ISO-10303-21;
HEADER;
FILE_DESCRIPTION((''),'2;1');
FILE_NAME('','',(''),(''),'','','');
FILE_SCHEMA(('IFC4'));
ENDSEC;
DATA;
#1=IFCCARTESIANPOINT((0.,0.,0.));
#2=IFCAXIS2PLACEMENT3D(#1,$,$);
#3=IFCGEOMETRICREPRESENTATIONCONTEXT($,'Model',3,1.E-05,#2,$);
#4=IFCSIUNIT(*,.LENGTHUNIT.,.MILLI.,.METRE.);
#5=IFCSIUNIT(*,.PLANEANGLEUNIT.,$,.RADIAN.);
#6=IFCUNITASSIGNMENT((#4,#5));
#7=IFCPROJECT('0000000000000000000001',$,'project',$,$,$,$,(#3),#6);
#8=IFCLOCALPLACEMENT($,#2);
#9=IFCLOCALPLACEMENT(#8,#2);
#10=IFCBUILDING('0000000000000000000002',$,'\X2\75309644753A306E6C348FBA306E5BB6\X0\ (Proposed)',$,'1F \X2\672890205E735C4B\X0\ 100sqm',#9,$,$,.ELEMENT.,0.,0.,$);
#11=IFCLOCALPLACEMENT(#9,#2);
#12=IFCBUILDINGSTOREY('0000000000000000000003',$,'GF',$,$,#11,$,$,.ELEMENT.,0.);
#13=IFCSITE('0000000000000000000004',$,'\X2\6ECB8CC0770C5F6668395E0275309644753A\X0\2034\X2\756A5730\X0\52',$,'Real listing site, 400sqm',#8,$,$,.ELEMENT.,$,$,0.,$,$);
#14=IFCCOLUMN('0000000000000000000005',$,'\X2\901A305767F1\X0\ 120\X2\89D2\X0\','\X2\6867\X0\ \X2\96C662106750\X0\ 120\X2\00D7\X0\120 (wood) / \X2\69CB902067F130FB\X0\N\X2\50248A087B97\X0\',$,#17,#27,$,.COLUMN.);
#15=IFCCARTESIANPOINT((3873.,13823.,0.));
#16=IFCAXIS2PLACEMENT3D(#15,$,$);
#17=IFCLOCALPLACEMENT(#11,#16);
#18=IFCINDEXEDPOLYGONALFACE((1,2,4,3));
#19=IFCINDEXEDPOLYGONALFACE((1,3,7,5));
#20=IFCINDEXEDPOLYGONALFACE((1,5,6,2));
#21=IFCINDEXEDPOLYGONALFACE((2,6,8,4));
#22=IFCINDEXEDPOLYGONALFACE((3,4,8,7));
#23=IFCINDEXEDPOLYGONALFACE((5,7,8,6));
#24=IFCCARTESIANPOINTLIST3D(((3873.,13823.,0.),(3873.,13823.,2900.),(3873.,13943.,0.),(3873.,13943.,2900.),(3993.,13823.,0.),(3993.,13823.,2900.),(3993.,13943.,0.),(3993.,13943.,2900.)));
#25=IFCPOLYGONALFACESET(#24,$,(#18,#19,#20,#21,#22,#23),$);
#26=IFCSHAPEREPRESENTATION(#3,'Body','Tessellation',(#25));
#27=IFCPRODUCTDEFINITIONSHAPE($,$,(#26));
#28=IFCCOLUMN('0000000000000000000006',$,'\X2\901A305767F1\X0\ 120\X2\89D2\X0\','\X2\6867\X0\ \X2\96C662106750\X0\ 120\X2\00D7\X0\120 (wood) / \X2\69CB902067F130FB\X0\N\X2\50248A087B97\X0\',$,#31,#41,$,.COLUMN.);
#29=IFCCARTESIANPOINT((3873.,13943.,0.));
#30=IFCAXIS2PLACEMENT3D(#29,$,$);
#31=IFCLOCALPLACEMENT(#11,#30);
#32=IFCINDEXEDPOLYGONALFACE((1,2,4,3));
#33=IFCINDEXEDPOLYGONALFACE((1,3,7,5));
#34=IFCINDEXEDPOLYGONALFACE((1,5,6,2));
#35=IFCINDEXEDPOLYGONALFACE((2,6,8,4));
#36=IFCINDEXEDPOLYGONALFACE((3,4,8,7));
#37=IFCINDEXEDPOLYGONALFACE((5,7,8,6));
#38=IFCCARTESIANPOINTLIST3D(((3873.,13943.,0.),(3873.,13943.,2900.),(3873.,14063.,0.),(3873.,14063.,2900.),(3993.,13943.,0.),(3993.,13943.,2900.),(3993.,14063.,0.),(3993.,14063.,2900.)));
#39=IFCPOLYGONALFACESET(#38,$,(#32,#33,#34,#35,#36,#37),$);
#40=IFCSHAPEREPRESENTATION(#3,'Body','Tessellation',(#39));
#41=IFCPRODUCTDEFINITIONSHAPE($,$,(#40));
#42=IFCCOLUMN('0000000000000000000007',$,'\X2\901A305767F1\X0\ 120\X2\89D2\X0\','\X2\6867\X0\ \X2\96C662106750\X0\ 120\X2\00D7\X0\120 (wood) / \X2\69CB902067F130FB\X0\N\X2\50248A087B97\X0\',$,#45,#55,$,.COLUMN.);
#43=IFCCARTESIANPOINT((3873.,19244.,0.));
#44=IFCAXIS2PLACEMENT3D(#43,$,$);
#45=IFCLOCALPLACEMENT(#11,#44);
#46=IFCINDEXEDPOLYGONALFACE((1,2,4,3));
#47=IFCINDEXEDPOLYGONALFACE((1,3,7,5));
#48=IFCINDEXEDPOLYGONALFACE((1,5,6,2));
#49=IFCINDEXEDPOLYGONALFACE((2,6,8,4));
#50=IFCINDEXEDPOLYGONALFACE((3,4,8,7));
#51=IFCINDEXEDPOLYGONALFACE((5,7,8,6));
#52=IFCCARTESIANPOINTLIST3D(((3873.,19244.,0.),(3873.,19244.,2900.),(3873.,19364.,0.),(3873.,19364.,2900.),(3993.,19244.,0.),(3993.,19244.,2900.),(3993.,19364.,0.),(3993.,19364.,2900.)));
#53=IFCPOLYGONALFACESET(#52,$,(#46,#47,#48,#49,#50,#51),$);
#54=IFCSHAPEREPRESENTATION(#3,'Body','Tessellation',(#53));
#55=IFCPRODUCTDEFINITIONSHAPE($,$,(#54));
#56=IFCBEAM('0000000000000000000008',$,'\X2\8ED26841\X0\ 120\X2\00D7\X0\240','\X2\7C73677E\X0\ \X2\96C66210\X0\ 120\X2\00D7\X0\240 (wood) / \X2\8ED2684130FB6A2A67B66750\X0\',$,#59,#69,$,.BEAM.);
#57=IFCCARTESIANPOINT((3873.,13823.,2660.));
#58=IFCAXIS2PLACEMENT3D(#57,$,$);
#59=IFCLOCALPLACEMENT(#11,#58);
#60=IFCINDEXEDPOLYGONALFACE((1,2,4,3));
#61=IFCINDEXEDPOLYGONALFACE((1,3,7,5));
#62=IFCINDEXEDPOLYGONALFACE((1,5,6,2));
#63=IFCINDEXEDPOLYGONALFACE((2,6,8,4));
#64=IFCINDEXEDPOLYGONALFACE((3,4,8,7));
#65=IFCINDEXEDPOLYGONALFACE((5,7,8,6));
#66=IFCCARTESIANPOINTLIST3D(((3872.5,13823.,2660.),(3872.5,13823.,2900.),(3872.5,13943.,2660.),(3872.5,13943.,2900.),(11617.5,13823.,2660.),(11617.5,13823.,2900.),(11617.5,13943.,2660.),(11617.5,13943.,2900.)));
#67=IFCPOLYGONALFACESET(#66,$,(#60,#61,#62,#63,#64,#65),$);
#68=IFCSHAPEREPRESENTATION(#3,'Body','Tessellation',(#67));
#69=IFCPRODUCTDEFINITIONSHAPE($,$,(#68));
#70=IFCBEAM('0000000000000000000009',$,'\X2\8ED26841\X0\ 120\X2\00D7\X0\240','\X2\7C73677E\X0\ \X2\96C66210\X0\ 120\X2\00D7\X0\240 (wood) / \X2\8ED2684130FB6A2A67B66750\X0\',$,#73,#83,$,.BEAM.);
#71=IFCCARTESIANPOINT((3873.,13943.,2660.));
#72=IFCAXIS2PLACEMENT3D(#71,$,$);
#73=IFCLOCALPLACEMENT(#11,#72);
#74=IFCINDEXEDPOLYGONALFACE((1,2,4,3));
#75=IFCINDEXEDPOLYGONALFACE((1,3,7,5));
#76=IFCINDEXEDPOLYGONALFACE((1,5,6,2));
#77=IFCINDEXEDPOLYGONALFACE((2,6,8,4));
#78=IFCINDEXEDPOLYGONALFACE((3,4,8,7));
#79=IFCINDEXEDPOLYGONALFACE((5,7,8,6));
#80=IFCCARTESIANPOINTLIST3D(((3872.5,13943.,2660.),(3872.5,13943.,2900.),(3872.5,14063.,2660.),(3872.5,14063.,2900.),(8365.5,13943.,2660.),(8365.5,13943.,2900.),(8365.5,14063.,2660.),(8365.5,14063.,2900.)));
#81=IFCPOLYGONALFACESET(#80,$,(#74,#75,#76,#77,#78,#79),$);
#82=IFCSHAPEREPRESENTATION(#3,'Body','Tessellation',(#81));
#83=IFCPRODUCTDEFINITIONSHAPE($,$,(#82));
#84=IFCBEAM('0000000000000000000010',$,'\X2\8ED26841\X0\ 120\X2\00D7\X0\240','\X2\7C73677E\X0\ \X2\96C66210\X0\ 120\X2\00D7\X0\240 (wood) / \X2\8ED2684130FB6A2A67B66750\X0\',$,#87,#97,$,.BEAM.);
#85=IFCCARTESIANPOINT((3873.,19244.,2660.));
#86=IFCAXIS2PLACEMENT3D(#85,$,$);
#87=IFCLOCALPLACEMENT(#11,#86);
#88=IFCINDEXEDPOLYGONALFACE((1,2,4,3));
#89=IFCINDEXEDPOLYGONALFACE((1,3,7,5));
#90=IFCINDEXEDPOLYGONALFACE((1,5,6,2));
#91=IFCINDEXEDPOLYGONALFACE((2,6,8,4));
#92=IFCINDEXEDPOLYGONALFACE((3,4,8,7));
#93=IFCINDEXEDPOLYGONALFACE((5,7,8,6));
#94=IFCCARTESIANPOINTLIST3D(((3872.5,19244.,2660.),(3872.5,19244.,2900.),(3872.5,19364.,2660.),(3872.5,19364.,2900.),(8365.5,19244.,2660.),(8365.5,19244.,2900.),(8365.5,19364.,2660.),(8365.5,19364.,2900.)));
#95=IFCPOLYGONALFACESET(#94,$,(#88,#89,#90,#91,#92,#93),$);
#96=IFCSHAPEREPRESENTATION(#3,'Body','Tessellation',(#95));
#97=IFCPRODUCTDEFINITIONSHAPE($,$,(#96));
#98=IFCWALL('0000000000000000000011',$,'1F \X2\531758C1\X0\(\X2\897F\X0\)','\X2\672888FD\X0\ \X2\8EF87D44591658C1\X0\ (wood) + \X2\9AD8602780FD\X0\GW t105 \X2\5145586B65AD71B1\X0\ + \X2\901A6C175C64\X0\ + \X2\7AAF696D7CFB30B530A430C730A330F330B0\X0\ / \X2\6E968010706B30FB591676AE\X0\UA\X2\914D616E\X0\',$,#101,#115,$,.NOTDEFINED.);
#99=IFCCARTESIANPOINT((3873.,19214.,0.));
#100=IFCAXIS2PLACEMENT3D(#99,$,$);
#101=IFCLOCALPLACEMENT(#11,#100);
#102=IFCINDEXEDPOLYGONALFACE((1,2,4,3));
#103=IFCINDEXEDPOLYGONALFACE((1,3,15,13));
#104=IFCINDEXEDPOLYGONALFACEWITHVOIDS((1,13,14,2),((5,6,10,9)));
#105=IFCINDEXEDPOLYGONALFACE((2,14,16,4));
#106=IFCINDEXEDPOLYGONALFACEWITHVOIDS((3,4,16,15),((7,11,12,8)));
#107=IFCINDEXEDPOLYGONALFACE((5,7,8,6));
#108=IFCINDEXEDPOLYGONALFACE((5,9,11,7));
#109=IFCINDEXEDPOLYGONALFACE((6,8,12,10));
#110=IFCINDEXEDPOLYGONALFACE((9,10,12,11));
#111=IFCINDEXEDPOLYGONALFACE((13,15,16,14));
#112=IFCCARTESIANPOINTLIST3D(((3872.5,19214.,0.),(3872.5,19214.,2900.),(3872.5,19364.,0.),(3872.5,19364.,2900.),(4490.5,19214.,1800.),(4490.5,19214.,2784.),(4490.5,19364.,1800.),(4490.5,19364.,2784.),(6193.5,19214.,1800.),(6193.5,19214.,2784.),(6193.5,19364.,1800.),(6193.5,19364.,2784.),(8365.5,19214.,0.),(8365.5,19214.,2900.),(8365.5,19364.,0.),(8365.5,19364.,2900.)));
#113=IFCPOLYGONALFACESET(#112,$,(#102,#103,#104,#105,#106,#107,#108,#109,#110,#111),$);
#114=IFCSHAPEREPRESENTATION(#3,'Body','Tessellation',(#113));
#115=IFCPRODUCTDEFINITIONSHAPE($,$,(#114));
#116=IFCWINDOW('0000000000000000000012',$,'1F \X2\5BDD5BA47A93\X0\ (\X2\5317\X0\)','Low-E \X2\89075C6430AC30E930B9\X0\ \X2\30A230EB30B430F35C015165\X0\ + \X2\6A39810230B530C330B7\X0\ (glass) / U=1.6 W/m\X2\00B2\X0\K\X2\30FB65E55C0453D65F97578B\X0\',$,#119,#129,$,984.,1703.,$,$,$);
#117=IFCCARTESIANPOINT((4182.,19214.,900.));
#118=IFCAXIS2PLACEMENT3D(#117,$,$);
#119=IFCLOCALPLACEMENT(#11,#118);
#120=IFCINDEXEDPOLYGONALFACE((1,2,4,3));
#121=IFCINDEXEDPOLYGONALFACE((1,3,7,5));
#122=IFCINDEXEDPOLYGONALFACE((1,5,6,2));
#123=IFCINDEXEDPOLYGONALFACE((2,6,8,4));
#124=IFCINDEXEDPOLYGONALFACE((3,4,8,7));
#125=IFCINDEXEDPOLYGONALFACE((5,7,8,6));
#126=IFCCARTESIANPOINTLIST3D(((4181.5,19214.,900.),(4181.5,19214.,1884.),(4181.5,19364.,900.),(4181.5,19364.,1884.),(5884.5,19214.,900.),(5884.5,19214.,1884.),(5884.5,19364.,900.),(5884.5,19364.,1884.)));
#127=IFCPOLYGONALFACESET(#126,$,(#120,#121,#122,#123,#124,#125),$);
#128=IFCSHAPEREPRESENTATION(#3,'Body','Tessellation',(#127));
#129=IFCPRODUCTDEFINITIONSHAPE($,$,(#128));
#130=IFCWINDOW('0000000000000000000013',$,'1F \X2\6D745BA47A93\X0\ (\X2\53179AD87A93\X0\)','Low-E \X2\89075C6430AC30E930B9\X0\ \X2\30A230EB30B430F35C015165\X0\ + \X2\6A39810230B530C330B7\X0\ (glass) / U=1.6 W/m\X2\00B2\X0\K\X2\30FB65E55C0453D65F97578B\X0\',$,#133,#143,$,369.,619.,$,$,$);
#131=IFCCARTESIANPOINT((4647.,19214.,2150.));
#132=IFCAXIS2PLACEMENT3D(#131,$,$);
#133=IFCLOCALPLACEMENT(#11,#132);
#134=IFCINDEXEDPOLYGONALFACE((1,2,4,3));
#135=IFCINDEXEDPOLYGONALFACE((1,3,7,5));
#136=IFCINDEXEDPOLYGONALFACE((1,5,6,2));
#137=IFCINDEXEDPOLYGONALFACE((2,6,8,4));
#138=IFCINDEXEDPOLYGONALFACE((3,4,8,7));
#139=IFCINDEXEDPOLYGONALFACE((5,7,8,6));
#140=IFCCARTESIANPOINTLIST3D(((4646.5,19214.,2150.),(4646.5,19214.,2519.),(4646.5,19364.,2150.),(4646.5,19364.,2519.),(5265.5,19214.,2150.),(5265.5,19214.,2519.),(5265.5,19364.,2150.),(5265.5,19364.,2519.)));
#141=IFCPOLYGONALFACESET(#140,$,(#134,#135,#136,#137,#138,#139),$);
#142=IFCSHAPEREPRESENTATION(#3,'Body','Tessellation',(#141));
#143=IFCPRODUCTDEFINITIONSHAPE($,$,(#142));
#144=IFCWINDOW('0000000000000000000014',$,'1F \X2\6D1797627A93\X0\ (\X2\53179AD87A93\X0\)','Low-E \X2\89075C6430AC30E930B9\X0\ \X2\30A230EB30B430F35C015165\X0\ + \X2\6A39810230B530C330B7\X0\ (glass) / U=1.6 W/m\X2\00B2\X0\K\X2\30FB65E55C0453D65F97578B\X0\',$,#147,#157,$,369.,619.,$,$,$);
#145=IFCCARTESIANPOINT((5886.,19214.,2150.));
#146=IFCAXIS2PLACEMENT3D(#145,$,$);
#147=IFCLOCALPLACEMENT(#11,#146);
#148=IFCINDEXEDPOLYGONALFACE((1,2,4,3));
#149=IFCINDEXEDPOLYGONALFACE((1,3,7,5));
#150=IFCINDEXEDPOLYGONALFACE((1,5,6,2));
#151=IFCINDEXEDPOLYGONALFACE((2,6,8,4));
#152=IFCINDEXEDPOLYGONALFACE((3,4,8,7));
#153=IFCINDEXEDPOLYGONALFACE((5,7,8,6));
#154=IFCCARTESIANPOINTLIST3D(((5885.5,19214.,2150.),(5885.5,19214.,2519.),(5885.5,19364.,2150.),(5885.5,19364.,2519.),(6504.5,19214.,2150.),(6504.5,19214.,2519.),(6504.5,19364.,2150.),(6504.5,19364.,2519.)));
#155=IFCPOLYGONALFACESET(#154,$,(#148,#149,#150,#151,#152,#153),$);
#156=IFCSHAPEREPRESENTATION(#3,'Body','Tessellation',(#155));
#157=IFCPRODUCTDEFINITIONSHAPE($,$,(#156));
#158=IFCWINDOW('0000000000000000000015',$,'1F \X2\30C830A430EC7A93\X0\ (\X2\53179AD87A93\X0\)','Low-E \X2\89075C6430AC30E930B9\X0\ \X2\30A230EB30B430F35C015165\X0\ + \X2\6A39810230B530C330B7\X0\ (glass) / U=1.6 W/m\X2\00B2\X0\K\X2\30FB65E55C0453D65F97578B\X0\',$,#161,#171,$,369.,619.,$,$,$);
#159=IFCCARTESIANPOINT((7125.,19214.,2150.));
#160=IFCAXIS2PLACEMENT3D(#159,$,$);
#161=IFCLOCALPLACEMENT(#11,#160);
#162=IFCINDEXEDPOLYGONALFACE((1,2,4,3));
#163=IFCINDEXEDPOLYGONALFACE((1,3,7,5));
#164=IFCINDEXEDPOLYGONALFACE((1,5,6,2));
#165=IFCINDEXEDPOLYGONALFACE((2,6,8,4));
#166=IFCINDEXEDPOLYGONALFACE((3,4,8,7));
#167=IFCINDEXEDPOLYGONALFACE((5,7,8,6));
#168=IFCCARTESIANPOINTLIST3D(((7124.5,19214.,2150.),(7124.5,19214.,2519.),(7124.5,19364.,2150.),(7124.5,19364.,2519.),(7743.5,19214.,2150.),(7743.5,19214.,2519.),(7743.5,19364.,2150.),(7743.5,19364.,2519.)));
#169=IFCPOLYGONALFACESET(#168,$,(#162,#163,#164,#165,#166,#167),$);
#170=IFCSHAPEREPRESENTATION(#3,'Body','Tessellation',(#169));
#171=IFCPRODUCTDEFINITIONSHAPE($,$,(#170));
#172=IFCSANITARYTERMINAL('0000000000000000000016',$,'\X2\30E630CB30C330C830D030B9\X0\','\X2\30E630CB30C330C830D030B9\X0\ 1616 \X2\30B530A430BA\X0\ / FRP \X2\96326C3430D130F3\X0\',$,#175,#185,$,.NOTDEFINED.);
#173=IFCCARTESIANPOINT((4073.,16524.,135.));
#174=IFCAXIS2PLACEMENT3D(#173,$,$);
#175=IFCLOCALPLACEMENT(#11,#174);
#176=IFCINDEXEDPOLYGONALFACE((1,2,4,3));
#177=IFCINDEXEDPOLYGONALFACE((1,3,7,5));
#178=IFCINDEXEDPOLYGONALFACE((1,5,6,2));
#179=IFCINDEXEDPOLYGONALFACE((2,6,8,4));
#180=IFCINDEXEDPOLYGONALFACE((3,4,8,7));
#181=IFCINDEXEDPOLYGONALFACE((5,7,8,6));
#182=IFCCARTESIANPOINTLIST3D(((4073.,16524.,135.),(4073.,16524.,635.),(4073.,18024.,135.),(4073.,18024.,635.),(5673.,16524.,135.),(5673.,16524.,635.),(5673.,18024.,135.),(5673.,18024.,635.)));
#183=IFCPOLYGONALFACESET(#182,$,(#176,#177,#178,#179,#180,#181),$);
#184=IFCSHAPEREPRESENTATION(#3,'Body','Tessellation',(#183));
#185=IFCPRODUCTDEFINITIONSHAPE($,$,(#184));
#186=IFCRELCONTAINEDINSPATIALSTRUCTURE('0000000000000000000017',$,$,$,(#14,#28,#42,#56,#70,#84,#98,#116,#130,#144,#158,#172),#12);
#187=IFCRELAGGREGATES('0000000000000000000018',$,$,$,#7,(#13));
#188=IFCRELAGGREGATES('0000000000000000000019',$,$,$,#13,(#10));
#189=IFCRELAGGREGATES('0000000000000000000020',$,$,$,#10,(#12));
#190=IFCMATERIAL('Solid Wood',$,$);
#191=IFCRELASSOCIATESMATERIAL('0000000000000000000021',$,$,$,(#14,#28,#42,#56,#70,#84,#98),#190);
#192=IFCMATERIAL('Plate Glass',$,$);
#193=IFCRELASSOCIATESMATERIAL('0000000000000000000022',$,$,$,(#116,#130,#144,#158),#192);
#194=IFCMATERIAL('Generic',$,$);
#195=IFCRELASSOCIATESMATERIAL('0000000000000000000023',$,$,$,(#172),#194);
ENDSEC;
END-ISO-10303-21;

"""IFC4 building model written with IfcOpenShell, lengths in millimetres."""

from ifc_helpers import new_model, si_unit, frame, frame_2d, origin, place, context, project, spatial, rectangle, extrude, material, element, fill, save


model = new_model("IFC4")

# Units and contexts
model_context = context("Model", 3, precision=1e-05, world=origin())
ifc_project = project(units=[si_unit("LENGTHUNIT", "METRE", prefix="MILLI"), si_unit("PLANEANGLEUNIT", "RADIAN")], contexts=[model_context])

# Site, building, storey
site_placement = place(None, origin())
site = spatial("IfcSite", under=ifc_project, at=site_placement, Name="滋賀県彦根市田附町2034番地52", ObjectType="Real listing site, 400sqm", CompositionType="ELEMENT", RefElevation=0.0)
building_placement = place(site_placement, origin())
building = spatial("IfcBuilding", under=site, at=building_placement, Name="田附町の水辺の家 (Proposed)", ObjectType="1F 木造平屋 100sqm", CompositionType="ELEMENT", ElevationOfRefHeight=0.0, ElevationOfTerrain=0.0)
storey_placement = place(building_placement, origin())
storey = spatial("IfcBuildingStorey", under=building, at=storey_placement, Name="GF", CompositionType="ELEMENT", Elevation=0.0)

# Columns
ifc_material_1 = material(Name="Solid Wood")
column_1_placement = place(storey_placement, frame((3873.0, 13823.0, 0.0)))
element("IfcColumn", 1, at=column_1_placement, inside=storey, material=ifc_material_1, Name="通し柱 120角", Description="桧 集成材 120×120 (wood) / 構造柱・N値計算", PredefinedType="COLUMN", context=model_context, shape_type="SweptSolid", body=[
    extrude(rectangle(XDim=120.0, YDim=120.0, at=frame_2d((60.0, 60.0))), frame((3873.0, 13823.0, 0.0)), (0.0, 0.0, 1.0), 2900.0),
])
column_2_placement = place(storey_placement, frame((3873.0, 13943.0, 0.0)))
element("IfcColumn", 2, at=column_2_placement, inside=storey, material=ifc_material_1, Name="通し柱 120角", Description="桧 集成材 120×120 (wood) / 構造柱・N値計算", PredefinedType="COLUMN", context=model_context, shape_type="SweptSolid", body=[
    extrude(rectangle(XDim=120.0, YDim=120.0, at=frame_2d((60.0, 60.0))), frame((3873.0, 13943.0, 0.0)), (0.0, 0.0, 1.0), 2900.0),
])
column_3_placement = place(storey_placement, frame((3873.0, 19244.0, 0.0)))
element("IfcColumn", 3, at=column_3_placement, inside=storey, material=ifc_material_1, Name="通し柱 120角", Description="桧 集成材 120×120 (wood) / 構造柱・N値計算", PredefinedType="COLUMN", context=model_context, shape_type="SweptSolid", body=[
    extrude(rectangle(XDim=120.0, YDim=120.0, at=frame_2d((60.0, 60.0))), frame((3873.0, 19244.0, 0.0)), (0.0, 0.0, 1.0), 2900.0),
])

# Beams
beam_1_placement = place(storey_placement, frame((3873.0, 13823.0, 2660.0)))
element("IfcBeam", 4, at=beam_1_placement, inside=storey, material=ifc_material_1, Name="軒桁 120×240", Description="米松 集成 120×240 (wood) / 軒桁・横架材", PredefinedType="BEAM", context=model_context, shape_type="SweptSolid", body=[
    extrude(rectangle(XDim=7745.0, YDim=120.0, at=frame_2d((3872.0, 60.0))), frame((3873.0, 13823.0, 2660.0)), (0.0, 0.0, 1.0), 240.0),
])
beam_2_placement = place(storey_placement, frame((3873.0, 13943.0, 2660.0)))
element("IfcBeam", 5, at=beam_2_placement, inside=storey, material=ifc_material_1, Name="軒桁 120×240", Description="米松 集成 120×240 (wood) / 軒桁・横架材", PredefinedType="BEAM", context=model_context, shape_type="SweptSolid", body=[
    extrude(rectangle(XDim=4493.0, YDim=120.0, at=frame_2d((2246.0, 60.0))), frame((3873.0, 13943.0, 2660.0)), (0.0, 0.0, 1.0), 240.0),
])
beam_3_placement = place(storey_placement, frame((3873.0, 19244.0, 2660.0)))
element("IfcBeam", 6, at=beam_3_placement, inside=storey, material=ifc_material_1, Name="軒桁 120×240", Description="米松 集成 120×240 (wood) / 軒桁・横架材", PredefinedType="BEAM", context=model_context, shape_type="SweptSolid", body=[
    extrude(rectangle(XDim=4493.0, YDim=120.0, at=frame_2d((2246.0, 60.0))), frame((3873.0, 19244.0, 2660.0)), (0.0, 0.0, 1.0), 240.0),
])

# Wall, openings, windows
wall_1_placement = place(storey_placement, frame((3873.0, 19214.0, 0.0)))
wall_1 = element("IfcWall", 7, at=wall_1_placement, inside=storey, material=ifc_material_1, Name="1F 北壁(西)", Description="木製 軸組外壁 (wood) + 高性能GW t105 充填断熱 + 通気層 + 窯業系サイディング / 準耐火・外皮UA配慮", PredefinedType="NOTDEFINED", context=model_context, shape_type="SweptSolid", body=[
    extrude(rectangle(XDim=4493.0, YDim=150.0, at=frame_2d((2246.0, 75.0))), frame((3873.0, 19214.0, 0.0)), (0.0, 0.0, 1.0), 2900.0),
])
opening_1_placement = place(storey_placement, frame((4182.0, 19214.0, 900.0)))
opening_1 = element("IfcOpeningElement", 8, at=opening_1_placement, cuts=wall_1, PredefinedType="NOTDEFINED", context=model_context, shape_type="SweptSolid", body=[
    extrude(rectangle(XDim=1703.0, YDim=150.0, at=frame_2d((851.0, 75.0))), frame((4182.0, 19214.0, 900.0)), (0.0, 0.0, 1.0), 984.0),
])
opening_2_placement = place(storey_placement, frame((4647.0, 19214.0, 2150.0)))
opening_2 = element("IfcOpeningElement", 9, at=opening_2_placement, cuts=wall_1, PredefinedType="NOTDEFINED", context=model_context, shape_type="SweptSolid", body=[
    extrude(rectangle(XDim=619.0, YDim=150.0, at=frame_2d((309.0, 75.0))), frame((4647.0, 19214.0, 2150.0)), (0.0, 0.0, 1.0), 369.0),
])
opening_3_placement = place(storey_placement, frame((5886.0, 19214.0, 2150.0)))
opening_3 = element("IfcOpeningElement", 10, at=opening_3_placement, cuts=wall_1, PredefinedType="NOTDEFINED", context=model_context, shape_type="SweptSolid", body=[
    extrude(rectangle(XDim=619.0, YDim=150.0, at=frame_2d((309.0, 75.0))), frame((5886.0, 19214.0, 2150.0)), (0.0, 0.0, 1.0), 369.0),
])
opening_4_placement = place(storey_placement, frame((7125.0, 19214.0, 2150.0)))
opening_4 = element("IfcOpeningElement", 11, at=opening_4_placement, cuts=wall_1, PredefinedType="NOTDEFINED", context=model_context, shape_type="SweptSolid", body=[
    extrude(rectangle(XDim=619.0, YDim=150.0, at=frame_2d((309.0, 75.0))), frame((7125.0, 19214.0, 2150.0)), (0.0, 0.0, 1.0), 369.0),
])
ifc_material_2 = material(Name="Plate Glass")
window_1_placement = place(storey_placement, frame((4182.0, 19214.0, 900.0)))
window_1 = element("IfcWindow", 12, at=window_1_placement, inside=storey, material=ifc_material_2, Name="1F 寝室窓 (北)", Description="Low-E 複層ガラス アルゴン封入 + 樹脂サッシ (glass) / U=1.6 W/m²K・日射取得型", OverallHeight=984.0, OverallWidth=1703.0, context=model_context, shape_type="SweptSolid", body=[
    extrude(rectangle(XDim=1703.0, YDim=150.0, at=frame_2d((851.0, 75.0))), frame((4182.0, 19214.0, 900.0)), (0.0, 0.0, 1.0), 984.0),
])
fill(opening_1, window_1)
window_2_placement = place(storey_placement, frame((4647.0, 19214.0, 2150.0)))
window_2 = element("IfcWindow", 13, at=window_2_placement, inside=storey, material=ifc_material_2, Name="1F 浴室窓 (北高窓)", Description="Low-E 複層ガラス アルゴン封入 + 樹脂サッシ (glass) / U=1.6 W/m²K・日射取得型", OverallHeight=369.0, OverallWidth=619.0, context=model_context, shape_type="SweptSolid", body=[
    extrude(rectangle(XDim=619.0, YDim=150.0, at=frame_2d((309.0, 75.0))), frame((4647.0, 19214.0, 2150.0)), (0.0, 0.0, 1.0), 369.0),
])
fill(opening_2, window_2)
window_3_placement = place(storey_placement, frame((5886.0, 19214.0, 2150.0)))
window_3 = element("IfcWindow", 14, at=window_3_placement, inside=storey, material=ifc_material_2, Name="1F 洗面窓 (北高窓)", Description="Low-E 複層ガラス アルゴン封入 + 樹脂サッシ (glass) / U=1.6 W/m²K・日射取得型", OverallHeight=369.0, OverallWidth=619.0, context=model_context, shape_type="SweptSolid", body=[
    extrude(rectangle(XDim=619.0, YDim=150.0, at=frame_2d((309.0, 75.0))), frame((5886.0, 19214.0, 2150.0)), (0.0, 0.0, 1.0), 369.0),
])
fill(opening_3, window_3)
window_4_placement = place(storey_placement, frame((7125.0, 19214.0, 2150.0)))
window_4 = element("IfcWindow", 15, at=window_4_placement, inside=storey, material=ifc_material_2, Name="1F トイレ窓 (北高窓)", Description="Low-E 複層ガラス アルゴン封入 + 樹脂サッシ (glass) / U=1.6 W/m²K・日射取得型", OverallHeight=369.0, OverallWidth=619.0, context=model_context, shape_type="SweptSolid", body=[
    extrude(rectangle(XDim=619.0, YDim=150.0, at=frame_2d((309.0, 75.0))), frame((7125.0, 19214.0, 2150.0)), (0.0, 0.0, 1.0), 369.0),
])
fill(opening_4, window_4)

# Shared definitions
ifc_material_3 = material(Name="Generic")

# Sanitary terminal
sanitary_terminal_placement = place(storey_placement, frame((4073.0, 16524.0, 135.0)))
element("IfcSanitaryTerminal", 16, at=sanitary_terminal_placement, inside=storey, material=ifc_material_3, Name="ユニットバス", Description="ユニットバス 1616 サイズ / FRP 防水パン", PredefinedType="NOTDEFINED", context=model_context, shape_type="SweptSolid", body=[
    extrude(rectangle(XDim=1600.0, YDim=1500.0, at=frame_2d((800.0, 750.0))), frame((4073.0, 16524.0, 135.0)), (0.0, 0.0, 1.0), 500.0),
])

save(model, "model.ifc")
